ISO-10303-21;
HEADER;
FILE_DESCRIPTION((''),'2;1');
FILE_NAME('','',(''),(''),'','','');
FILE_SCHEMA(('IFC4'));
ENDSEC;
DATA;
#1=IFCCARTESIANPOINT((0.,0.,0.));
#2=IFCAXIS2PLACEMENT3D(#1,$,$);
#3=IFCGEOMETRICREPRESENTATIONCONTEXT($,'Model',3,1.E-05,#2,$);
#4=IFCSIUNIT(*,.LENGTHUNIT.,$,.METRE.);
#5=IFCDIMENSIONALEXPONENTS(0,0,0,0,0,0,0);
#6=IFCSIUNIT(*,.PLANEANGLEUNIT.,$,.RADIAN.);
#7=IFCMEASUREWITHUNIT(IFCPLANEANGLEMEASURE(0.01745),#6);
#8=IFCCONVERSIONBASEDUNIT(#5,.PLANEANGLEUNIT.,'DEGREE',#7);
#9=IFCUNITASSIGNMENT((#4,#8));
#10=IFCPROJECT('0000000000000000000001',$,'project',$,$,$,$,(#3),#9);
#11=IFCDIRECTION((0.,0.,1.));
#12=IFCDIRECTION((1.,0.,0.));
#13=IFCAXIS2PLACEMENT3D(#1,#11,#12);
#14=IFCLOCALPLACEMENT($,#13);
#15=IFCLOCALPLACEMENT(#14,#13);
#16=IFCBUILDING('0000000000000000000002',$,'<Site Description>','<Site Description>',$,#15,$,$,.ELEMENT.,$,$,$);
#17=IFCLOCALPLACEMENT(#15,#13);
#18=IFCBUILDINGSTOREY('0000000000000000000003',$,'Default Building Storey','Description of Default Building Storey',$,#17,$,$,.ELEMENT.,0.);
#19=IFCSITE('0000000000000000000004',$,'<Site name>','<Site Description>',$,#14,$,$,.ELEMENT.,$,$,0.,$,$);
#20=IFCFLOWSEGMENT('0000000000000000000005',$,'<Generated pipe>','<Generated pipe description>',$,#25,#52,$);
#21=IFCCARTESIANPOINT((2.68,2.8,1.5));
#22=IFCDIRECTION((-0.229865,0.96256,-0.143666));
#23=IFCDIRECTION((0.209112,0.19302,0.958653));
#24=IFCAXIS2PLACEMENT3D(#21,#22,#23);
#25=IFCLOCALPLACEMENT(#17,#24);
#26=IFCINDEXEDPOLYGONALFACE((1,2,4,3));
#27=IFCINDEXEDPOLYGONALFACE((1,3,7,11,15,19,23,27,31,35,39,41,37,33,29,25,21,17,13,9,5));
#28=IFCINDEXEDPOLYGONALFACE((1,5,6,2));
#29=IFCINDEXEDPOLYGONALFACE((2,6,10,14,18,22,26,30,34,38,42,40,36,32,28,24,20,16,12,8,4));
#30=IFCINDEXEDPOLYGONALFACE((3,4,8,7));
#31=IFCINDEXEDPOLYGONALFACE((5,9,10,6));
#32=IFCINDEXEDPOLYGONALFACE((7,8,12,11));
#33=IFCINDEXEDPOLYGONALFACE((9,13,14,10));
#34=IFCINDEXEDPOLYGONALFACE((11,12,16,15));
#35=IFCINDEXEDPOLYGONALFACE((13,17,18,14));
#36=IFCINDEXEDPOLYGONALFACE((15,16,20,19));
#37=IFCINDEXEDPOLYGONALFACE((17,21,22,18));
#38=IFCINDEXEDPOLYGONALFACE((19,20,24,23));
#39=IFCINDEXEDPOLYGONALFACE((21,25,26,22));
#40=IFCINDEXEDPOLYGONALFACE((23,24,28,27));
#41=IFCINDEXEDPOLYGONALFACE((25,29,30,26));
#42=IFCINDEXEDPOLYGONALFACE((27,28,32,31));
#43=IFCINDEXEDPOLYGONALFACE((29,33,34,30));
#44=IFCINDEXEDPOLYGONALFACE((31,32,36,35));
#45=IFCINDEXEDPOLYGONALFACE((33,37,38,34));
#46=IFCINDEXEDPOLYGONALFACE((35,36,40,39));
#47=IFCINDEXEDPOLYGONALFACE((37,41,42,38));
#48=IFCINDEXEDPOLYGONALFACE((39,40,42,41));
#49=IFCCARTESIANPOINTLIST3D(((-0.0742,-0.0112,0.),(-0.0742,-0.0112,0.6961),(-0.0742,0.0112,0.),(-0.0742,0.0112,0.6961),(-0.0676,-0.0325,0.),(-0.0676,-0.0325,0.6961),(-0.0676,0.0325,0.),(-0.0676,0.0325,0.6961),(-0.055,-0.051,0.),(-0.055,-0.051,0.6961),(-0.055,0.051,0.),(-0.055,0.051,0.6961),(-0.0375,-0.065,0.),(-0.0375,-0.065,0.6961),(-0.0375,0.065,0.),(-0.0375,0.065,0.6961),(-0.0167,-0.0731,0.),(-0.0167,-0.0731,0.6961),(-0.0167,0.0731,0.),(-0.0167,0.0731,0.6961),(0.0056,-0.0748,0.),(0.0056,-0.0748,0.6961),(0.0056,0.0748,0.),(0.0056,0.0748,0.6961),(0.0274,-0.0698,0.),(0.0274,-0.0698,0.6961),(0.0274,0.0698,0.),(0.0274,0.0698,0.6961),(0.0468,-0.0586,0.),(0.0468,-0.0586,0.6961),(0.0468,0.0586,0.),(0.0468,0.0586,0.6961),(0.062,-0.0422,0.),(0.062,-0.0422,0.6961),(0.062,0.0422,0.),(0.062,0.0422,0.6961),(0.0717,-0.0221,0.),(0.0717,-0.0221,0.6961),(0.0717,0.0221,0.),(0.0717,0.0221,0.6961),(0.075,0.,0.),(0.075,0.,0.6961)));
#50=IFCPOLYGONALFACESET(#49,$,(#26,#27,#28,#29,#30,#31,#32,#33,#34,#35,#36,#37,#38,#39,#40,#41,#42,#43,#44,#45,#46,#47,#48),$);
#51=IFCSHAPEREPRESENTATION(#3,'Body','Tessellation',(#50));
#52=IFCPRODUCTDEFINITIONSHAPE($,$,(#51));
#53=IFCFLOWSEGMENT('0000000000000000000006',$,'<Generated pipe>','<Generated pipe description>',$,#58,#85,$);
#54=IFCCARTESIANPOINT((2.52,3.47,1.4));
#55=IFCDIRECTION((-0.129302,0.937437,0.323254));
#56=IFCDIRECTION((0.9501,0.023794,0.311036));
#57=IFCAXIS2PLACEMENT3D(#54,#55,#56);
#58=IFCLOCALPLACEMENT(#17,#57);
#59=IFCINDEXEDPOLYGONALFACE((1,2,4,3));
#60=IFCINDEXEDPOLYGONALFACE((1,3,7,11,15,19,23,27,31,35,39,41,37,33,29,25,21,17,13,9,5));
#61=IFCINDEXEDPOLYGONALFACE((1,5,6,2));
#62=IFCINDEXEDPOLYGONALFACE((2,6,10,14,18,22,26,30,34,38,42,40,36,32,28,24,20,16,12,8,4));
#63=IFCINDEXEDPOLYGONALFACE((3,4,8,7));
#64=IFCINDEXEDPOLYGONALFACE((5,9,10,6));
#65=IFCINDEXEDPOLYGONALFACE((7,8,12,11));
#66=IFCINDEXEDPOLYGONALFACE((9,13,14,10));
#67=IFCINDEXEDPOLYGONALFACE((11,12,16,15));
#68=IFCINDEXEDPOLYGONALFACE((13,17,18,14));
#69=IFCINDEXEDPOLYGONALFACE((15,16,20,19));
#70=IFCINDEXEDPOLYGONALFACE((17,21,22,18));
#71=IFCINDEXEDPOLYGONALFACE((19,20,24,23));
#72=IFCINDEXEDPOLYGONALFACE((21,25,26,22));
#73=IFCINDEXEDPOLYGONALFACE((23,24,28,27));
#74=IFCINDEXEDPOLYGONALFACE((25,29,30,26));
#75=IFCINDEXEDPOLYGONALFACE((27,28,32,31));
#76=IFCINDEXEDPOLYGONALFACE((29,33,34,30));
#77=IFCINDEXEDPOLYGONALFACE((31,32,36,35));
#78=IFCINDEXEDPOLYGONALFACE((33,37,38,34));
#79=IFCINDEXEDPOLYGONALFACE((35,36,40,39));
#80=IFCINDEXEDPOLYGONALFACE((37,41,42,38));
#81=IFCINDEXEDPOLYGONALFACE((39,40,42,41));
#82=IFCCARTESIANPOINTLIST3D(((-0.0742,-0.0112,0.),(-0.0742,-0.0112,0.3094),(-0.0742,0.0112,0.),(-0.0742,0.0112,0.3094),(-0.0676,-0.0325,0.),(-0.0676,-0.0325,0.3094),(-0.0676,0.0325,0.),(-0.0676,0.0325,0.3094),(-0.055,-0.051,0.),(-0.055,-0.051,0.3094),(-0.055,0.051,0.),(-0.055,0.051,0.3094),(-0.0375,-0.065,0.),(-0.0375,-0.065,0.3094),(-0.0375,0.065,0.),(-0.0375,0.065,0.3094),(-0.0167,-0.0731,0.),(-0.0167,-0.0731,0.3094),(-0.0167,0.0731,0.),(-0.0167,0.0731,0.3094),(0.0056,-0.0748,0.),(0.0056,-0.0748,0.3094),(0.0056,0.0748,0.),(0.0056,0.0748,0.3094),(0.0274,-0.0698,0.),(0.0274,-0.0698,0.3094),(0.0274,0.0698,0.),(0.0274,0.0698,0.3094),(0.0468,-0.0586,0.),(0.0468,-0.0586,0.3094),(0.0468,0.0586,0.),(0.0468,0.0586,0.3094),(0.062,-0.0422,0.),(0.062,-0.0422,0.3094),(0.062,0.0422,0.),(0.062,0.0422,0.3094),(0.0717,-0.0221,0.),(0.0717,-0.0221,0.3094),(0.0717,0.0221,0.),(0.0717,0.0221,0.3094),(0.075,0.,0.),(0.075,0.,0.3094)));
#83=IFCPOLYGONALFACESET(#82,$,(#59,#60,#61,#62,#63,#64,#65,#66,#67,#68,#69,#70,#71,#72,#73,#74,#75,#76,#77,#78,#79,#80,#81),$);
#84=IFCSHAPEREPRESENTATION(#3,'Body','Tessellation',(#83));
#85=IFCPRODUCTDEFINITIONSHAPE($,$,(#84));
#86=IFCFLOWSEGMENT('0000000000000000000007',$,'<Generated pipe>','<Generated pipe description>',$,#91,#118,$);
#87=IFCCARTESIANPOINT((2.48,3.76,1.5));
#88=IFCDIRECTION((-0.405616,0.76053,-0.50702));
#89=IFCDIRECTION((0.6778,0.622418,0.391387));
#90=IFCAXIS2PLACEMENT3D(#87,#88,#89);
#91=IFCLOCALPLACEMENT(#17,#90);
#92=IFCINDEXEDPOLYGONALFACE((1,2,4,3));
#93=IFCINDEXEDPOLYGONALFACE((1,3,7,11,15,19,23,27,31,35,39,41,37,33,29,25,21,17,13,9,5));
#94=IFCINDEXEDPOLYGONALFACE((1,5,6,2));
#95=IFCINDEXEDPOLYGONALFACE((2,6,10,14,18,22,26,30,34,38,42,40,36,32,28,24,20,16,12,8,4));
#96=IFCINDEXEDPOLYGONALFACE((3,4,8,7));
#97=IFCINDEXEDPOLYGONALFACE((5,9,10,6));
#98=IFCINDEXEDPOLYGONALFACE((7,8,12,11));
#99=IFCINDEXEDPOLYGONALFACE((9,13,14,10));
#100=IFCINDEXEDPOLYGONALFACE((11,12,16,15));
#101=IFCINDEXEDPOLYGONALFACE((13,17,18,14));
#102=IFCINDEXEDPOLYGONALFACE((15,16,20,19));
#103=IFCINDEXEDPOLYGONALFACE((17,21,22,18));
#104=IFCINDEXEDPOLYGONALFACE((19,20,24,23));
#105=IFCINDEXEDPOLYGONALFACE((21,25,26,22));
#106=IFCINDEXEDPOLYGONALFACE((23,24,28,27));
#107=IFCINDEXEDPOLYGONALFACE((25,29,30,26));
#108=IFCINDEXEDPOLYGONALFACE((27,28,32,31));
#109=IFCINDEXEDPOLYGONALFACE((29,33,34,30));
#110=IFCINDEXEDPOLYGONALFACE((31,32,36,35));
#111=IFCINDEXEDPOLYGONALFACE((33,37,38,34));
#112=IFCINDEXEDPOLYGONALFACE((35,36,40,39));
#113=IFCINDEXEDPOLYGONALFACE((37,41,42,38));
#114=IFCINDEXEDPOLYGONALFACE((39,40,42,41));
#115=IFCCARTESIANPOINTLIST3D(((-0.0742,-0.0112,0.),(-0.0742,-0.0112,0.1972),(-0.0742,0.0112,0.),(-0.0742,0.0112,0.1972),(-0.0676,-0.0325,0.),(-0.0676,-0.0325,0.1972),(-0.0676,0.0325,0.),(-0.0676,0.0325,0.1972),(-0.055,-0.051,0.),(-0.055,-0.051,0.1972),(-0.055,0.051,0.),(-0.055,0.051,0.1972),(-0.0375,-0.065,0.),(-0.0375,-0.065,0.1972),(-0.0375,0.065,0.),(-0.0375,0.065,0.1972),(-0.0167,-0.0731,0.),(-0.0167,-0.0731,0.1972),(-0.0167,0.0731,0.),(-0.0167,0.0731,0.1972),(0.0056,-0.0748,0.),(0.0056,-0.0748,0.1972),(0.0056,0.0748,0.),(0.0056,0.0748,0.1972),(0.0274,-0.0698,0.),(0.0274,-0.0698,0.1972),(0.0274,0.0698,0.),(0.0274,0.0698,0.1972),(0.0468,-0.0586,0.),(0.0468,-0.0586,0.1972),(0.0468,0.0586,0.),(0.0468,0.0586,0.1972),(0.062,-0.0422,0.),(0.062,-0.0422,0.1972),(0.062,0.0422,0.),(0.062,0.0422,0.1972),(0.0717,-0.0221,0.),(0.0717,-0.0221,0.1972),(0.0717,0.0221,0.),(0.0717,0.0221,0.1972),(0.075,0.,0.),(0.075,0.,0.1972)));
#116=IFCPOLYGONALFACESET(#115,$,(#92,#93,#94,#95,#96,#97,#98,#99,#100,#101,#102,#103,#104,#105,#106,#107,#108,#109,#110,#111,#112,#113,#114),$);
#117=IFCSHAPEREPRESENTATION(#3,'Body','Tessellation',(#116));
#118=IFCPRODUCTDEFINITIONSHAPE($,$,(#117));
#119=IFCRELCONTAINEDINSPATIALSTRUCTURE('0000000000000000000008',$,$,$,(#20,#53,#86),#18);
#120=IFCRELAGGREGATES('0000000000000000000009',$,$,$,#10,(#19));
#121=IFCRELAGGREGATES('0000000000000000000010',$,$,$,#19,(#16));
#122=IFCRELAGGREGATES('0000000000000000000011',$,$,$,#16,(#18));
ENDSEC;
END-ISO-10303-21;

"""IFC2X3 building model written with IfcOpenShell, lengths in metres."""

from ifc_helpers import new_model, entity, si_unit, converted_unit, frame, origin, origin_with_axes, origin_2d_with_axis, place, context, project, spatial, circle, extrude, element, save


model = new_model("IFC2X3")

# Units and contexts
model_context = context("Model", 3, precision=1e-05, world=origin())
ifc_project = project(units=[si_unit("LENGTHUNIT", "METRE"), converted_unit("PLANEANGLEUNIT", "DEGREE", entity("IfcPlaneAngleMeasure", 0.01745), si_unit("PLANEANGLEUNIT", "RADIAN"), dimensions=[0, 0, 0, 0, 0, 0, 0])], contexts=[model_context])

# Site, building, storey
site_placement = place(None, origin_with_axes())
site = spatial("IfcSite", under=ifc_project, at=site_placement, Name="<Site name>", Description="<Site Description>", CompositionType="ELEMENT", RefElevation=0.0)
building_placement = place(site_placement, origin_with_axes())
building = spatial("IfcBuilding", under=site, at=building_placement, Name="<Site Description>", Description="<Site Description>", CompositionType="ELEMENT")
storey_placement = place(building_placement, origin_with_axes())
storey = spatial("IfcBuildingStorey", under=building, at=storey_placement, Name="Default Building Storey", Description="Description of Default Building Storey", CompositionType="ELEMENT", Elevation=0.0)

# Flow segments
flow_segment_1_placement = place(storey_placement, frame((2.68, 2.8, 1.5), z_axis=(-0.229865, 0.96256, -0.143666), x_axis=(0.209112, 0.19302, 0.958653)))
element("IfcFlowSegment", 1, at=flow_segment_1_placement, inside=storey, Name="<Generated pipe>", Description="<Generated pipe description>", context=model_context, shape_type="SweptSolid", body=[
    extrude(circle(Radius=0.075, at=origin_2d_with_axis()), origin_with_axes(), (0.0, 0.0, 1.0), 0.6961),
])
flow_segment_2_placement = place(storey_placement, frame((2.52, 3.47, 1.4), z_axis=(-0.129302, 0.937437, 0.323254), x_axis=(0.9501, 0.023794, 0.311036)))
element("IfcFlowSegment", 2, at=flow_segment_2_placement, inside=storey, Name="<Generated pipe>", Description="<Generated pipe description>", context=model_context, shape_type="SweptSolid", body=[
    extrude(circle(Radius=0.075, at=origin_2d_with_axis()), origin_with_axes(), (0.0, 0.0, 1.0), 0.3094),
])
flow_segment_3_placement = place(storey_placement, frame((2.48, 3.76, 1.5), z_axis=(-0.405616, 0.76053, -0.50702), x_axis=(0.6778, 0.622418, 0.391387)))
element("IfcFlowSegment", 3, at=flow_segment_3_placement, inside=storey, Name="<Generated pipe>", Description="<Generated pipe description>", context=model_context, shape_type="SweptSolid", body=[
    extrude(circle(Radius=0.075, at=origin_2d_with_axis()), origin_with_axes(), (0.0, 0.0, 1.0), 0.1972),
])

save(model, "model.ifc")
